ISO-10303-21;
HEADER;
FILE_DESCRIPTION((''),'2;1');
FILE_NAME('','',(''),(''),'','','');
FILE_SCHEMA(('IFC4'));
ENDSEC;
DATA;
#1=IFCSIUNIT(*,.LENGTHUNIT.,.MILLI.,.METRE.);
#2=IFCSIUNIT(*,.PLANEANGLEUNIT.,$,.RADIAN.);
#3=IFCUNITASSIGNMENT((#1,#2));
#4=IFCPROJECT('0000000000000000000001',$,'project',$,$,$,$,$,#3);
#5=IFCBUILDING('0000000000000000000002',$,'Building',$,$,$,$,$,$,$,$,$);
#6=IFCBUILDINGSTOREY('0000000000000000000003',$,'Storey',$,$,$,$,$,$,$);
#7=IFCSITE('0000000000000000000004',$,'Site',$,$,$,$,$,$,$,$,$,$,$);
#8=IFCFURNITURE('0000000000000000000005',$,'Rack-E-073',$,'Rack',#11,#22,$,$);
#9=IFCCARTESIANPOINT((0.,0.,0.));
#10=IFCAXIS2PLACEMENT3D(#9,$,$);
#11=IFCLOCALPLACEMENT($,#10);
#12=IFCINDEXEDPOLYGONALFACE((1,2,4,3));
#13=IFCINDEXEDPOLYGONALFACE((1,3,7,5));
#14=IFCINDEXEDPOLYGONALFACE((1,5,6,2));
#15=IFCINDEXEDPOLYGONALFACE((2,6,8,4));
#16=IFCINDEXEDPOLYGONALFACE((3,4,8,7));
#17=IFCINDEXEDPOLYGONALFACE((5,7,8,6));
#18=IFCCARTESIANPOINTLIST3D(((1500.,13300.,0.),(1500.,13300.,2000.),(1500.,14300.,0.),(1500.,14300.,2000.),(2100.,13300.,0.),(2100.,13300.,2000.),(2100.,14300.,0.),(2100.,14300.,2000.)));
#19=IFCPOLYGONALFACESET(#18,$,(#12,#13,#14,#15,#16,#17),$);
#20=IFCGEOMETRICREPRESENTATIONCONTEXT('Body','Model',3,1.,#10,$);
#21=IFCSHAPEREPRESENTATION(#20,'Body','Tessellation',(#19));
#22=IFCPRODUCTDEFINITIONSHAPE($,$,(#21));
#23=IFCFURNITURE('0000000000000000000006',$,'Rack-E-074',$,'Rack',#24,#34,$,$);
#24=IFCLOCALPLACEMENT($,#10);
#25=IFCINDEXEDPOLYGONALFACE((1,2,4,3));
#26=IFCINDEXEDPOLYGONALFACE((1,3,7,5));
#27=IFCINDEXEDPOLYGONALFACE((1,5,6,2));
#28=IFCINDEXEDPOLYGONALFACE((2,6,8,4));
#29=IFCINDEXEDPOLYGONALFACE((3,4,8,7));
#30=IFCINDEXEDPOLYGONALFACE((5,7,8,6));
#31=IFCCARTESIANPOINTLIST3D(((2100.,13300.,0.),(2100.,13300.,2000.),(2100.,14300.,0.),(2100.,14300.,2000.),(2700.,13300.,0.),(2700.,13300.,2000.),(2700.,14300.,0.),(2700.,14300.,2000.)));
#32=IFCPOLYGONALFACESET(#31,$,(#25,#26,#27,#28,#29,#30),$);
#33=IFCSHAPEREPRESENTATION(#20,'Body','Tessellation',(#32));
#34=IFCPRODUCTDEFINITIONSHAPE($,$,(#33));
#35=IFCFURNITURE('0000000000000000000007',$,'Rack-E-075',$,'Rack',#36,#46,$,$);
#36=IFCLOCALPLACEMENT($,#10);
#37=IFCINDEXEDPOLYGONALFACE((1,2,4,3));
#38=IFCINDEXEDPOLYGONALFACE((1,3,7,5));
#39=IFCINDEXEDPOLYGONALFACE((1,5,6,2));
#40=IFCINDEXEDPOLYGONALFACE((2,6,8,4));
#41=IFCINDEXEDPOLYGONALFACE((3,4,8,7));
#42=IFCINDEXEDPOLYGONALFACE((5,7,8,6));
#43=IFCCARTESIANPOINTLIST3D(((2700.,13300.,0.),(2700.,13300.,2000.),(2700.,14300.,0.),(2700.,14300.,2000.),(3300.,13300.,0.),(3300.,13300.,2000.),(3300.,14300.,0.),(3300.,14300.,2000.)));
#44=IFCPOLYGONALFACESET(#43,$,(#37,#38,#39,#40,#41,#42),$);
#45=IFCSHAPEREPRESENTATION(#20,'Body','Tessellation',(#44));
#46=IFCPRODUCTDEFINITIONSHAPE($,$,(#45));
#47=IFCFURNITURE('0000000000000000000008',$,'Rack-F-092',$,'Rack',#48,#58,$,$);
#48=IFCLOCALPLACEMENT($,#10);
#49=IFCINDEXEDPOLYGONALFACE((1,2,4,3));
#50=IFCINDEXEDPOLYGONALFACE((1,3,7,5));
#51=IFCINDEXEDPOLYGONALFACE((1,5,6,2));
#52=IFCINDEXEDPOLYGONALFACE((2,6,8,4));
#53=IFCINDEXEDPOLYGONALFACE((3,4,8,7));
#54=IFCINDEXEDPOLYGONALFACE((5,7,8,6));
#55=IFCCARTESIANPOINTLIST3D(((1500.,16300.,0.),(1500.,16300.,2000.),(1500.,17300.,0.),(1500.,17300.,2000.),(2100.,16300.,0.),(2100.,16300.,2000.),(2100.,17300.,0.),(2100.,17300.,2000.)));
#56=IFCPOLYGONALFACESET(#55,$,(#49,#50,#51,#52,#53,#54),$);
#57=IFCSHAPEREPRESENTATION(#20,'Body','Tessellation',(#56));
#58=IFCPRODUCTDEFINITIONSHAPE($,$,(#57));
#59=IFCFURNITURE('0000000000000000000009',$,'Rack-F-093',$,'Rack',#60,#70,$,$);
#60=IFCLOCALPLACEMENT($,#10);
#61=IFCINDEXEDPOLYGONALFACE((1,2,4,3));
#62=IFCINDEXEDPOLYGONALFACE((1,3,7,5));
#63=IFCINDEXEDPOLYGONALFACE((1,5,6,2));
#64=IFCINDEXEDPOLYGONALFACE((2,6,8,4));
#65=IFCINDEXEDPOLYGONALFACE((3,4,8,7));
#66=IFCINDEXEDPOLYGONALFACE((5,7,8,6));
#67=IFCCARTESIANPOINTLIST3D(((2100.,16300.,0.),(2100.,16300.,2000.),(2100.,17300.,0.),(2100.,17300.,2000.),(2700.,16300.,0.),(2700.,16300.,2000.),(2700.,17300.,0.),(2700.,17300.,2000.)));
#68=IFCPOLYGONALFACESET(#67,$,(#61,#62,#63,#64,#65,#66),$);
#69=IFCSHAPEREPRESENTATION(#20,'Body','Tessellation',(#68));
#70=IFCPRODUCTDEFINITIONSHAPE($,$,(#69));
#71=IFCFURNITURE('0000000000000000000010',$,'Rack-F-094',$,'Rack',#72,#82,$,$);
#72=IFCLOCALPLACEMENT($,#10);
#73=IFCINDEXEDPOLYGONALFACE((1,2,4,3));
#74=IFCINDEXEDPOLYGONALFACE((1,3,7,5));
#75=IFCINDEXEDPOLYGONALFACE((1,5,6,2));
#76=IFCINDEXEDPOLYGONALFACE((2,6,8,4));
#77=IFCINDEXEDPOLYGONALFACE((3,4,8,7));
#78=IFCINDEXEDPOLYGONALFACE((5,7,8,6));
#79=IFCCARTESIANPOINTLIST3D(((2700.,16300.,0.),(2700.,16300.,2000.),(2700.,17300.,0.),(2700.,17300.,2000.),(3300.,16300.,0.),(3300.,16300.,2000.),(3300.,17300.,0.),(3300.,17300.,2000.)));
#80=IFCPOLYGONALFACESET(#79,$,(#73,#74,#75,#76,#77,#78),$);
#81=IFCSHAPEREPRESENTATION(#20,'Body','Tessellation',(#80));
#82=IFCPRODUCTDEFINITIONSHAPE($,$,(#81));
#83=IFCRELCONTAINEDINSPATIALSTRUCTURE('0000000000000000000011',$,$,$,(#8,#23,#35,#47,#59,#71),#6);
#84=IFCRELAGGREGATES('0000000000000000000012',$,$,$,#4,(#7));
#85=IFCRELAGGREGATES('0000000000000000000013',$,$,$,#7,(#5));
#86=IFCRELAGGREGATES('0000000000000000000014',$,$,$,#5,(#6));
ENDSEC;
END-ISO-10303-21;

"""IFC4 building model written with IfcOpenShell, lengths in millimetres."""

from ifc_helpers import new_model, si_unit, frame, origin, place, context, project, spatial, rectangle, extrude, element, save


model = new_model("IFC4")

# Units and contexts
model_context = context("Model", 3, precision=1.0, world=origin(), identifier="Body")
ifc_project = project(units=[si_unit("LENGTHUNIT", "METRE", prefix="MILLI"), si_unit("PLANEANGLEUNIT", "RADIAN")])

# Site, building, storey
site = spatial("IfcSite", under=ifc_project, Name="Site")
building = spatial("IfcBuilding", under=site, Name="Building")
storey = spatial("IfcBuildingStorey", under=building, Name="Storey")

# Furniture
for number, where, z_axis, x_axis, name in (
    (1, (1800.0, 13800.0, 0.0), (0.0, 0.0, 1.0), (1.0, 0.0, 0.0), "Rack-E-073"),
    (2, (2400.0, 13800.0, 0.0), (0.0, 0.0, 1.0), (1.0, 0.0, 0.0), "Rack-E-074"),
    (3, (3000.0, 13800.0, 0.0), (0.0, 0.0, 1.0), (1.0, 0.0, 0.0), "Rack-E-075"),
    (4, (1800.0, 16800.0, 0.0), (0.0, 0.0, 1.0), (1.0, 0.0, 0.0), "Rack-F-092"),
    (5, (2400.0, 16800.0, 0.0), (0.0, 0.0, 1.0), (1.0, 0.0, 0.0), "Rack-F-093"),
    (6, (3000.0, 16800.0, 0.0), (0.0, 0.0, 1.0), (1.0, 0.0, 0.0), "Rack-F-094"),
):
    element("IfcFurniture", number, at=place(None, frame(where, z_axis=z_axis, x_axis=x_axis)), inside=storey, Name=name, ObjectType="Rack", context=model_context, shape_type="SweptSolid", body=[
        extrude(rectangle(XDim=600.0, YDim=1000.0), origin(), (0.0, 0.0, 1.0), 2000.0),
    ])

save(model, "model.ifc")
